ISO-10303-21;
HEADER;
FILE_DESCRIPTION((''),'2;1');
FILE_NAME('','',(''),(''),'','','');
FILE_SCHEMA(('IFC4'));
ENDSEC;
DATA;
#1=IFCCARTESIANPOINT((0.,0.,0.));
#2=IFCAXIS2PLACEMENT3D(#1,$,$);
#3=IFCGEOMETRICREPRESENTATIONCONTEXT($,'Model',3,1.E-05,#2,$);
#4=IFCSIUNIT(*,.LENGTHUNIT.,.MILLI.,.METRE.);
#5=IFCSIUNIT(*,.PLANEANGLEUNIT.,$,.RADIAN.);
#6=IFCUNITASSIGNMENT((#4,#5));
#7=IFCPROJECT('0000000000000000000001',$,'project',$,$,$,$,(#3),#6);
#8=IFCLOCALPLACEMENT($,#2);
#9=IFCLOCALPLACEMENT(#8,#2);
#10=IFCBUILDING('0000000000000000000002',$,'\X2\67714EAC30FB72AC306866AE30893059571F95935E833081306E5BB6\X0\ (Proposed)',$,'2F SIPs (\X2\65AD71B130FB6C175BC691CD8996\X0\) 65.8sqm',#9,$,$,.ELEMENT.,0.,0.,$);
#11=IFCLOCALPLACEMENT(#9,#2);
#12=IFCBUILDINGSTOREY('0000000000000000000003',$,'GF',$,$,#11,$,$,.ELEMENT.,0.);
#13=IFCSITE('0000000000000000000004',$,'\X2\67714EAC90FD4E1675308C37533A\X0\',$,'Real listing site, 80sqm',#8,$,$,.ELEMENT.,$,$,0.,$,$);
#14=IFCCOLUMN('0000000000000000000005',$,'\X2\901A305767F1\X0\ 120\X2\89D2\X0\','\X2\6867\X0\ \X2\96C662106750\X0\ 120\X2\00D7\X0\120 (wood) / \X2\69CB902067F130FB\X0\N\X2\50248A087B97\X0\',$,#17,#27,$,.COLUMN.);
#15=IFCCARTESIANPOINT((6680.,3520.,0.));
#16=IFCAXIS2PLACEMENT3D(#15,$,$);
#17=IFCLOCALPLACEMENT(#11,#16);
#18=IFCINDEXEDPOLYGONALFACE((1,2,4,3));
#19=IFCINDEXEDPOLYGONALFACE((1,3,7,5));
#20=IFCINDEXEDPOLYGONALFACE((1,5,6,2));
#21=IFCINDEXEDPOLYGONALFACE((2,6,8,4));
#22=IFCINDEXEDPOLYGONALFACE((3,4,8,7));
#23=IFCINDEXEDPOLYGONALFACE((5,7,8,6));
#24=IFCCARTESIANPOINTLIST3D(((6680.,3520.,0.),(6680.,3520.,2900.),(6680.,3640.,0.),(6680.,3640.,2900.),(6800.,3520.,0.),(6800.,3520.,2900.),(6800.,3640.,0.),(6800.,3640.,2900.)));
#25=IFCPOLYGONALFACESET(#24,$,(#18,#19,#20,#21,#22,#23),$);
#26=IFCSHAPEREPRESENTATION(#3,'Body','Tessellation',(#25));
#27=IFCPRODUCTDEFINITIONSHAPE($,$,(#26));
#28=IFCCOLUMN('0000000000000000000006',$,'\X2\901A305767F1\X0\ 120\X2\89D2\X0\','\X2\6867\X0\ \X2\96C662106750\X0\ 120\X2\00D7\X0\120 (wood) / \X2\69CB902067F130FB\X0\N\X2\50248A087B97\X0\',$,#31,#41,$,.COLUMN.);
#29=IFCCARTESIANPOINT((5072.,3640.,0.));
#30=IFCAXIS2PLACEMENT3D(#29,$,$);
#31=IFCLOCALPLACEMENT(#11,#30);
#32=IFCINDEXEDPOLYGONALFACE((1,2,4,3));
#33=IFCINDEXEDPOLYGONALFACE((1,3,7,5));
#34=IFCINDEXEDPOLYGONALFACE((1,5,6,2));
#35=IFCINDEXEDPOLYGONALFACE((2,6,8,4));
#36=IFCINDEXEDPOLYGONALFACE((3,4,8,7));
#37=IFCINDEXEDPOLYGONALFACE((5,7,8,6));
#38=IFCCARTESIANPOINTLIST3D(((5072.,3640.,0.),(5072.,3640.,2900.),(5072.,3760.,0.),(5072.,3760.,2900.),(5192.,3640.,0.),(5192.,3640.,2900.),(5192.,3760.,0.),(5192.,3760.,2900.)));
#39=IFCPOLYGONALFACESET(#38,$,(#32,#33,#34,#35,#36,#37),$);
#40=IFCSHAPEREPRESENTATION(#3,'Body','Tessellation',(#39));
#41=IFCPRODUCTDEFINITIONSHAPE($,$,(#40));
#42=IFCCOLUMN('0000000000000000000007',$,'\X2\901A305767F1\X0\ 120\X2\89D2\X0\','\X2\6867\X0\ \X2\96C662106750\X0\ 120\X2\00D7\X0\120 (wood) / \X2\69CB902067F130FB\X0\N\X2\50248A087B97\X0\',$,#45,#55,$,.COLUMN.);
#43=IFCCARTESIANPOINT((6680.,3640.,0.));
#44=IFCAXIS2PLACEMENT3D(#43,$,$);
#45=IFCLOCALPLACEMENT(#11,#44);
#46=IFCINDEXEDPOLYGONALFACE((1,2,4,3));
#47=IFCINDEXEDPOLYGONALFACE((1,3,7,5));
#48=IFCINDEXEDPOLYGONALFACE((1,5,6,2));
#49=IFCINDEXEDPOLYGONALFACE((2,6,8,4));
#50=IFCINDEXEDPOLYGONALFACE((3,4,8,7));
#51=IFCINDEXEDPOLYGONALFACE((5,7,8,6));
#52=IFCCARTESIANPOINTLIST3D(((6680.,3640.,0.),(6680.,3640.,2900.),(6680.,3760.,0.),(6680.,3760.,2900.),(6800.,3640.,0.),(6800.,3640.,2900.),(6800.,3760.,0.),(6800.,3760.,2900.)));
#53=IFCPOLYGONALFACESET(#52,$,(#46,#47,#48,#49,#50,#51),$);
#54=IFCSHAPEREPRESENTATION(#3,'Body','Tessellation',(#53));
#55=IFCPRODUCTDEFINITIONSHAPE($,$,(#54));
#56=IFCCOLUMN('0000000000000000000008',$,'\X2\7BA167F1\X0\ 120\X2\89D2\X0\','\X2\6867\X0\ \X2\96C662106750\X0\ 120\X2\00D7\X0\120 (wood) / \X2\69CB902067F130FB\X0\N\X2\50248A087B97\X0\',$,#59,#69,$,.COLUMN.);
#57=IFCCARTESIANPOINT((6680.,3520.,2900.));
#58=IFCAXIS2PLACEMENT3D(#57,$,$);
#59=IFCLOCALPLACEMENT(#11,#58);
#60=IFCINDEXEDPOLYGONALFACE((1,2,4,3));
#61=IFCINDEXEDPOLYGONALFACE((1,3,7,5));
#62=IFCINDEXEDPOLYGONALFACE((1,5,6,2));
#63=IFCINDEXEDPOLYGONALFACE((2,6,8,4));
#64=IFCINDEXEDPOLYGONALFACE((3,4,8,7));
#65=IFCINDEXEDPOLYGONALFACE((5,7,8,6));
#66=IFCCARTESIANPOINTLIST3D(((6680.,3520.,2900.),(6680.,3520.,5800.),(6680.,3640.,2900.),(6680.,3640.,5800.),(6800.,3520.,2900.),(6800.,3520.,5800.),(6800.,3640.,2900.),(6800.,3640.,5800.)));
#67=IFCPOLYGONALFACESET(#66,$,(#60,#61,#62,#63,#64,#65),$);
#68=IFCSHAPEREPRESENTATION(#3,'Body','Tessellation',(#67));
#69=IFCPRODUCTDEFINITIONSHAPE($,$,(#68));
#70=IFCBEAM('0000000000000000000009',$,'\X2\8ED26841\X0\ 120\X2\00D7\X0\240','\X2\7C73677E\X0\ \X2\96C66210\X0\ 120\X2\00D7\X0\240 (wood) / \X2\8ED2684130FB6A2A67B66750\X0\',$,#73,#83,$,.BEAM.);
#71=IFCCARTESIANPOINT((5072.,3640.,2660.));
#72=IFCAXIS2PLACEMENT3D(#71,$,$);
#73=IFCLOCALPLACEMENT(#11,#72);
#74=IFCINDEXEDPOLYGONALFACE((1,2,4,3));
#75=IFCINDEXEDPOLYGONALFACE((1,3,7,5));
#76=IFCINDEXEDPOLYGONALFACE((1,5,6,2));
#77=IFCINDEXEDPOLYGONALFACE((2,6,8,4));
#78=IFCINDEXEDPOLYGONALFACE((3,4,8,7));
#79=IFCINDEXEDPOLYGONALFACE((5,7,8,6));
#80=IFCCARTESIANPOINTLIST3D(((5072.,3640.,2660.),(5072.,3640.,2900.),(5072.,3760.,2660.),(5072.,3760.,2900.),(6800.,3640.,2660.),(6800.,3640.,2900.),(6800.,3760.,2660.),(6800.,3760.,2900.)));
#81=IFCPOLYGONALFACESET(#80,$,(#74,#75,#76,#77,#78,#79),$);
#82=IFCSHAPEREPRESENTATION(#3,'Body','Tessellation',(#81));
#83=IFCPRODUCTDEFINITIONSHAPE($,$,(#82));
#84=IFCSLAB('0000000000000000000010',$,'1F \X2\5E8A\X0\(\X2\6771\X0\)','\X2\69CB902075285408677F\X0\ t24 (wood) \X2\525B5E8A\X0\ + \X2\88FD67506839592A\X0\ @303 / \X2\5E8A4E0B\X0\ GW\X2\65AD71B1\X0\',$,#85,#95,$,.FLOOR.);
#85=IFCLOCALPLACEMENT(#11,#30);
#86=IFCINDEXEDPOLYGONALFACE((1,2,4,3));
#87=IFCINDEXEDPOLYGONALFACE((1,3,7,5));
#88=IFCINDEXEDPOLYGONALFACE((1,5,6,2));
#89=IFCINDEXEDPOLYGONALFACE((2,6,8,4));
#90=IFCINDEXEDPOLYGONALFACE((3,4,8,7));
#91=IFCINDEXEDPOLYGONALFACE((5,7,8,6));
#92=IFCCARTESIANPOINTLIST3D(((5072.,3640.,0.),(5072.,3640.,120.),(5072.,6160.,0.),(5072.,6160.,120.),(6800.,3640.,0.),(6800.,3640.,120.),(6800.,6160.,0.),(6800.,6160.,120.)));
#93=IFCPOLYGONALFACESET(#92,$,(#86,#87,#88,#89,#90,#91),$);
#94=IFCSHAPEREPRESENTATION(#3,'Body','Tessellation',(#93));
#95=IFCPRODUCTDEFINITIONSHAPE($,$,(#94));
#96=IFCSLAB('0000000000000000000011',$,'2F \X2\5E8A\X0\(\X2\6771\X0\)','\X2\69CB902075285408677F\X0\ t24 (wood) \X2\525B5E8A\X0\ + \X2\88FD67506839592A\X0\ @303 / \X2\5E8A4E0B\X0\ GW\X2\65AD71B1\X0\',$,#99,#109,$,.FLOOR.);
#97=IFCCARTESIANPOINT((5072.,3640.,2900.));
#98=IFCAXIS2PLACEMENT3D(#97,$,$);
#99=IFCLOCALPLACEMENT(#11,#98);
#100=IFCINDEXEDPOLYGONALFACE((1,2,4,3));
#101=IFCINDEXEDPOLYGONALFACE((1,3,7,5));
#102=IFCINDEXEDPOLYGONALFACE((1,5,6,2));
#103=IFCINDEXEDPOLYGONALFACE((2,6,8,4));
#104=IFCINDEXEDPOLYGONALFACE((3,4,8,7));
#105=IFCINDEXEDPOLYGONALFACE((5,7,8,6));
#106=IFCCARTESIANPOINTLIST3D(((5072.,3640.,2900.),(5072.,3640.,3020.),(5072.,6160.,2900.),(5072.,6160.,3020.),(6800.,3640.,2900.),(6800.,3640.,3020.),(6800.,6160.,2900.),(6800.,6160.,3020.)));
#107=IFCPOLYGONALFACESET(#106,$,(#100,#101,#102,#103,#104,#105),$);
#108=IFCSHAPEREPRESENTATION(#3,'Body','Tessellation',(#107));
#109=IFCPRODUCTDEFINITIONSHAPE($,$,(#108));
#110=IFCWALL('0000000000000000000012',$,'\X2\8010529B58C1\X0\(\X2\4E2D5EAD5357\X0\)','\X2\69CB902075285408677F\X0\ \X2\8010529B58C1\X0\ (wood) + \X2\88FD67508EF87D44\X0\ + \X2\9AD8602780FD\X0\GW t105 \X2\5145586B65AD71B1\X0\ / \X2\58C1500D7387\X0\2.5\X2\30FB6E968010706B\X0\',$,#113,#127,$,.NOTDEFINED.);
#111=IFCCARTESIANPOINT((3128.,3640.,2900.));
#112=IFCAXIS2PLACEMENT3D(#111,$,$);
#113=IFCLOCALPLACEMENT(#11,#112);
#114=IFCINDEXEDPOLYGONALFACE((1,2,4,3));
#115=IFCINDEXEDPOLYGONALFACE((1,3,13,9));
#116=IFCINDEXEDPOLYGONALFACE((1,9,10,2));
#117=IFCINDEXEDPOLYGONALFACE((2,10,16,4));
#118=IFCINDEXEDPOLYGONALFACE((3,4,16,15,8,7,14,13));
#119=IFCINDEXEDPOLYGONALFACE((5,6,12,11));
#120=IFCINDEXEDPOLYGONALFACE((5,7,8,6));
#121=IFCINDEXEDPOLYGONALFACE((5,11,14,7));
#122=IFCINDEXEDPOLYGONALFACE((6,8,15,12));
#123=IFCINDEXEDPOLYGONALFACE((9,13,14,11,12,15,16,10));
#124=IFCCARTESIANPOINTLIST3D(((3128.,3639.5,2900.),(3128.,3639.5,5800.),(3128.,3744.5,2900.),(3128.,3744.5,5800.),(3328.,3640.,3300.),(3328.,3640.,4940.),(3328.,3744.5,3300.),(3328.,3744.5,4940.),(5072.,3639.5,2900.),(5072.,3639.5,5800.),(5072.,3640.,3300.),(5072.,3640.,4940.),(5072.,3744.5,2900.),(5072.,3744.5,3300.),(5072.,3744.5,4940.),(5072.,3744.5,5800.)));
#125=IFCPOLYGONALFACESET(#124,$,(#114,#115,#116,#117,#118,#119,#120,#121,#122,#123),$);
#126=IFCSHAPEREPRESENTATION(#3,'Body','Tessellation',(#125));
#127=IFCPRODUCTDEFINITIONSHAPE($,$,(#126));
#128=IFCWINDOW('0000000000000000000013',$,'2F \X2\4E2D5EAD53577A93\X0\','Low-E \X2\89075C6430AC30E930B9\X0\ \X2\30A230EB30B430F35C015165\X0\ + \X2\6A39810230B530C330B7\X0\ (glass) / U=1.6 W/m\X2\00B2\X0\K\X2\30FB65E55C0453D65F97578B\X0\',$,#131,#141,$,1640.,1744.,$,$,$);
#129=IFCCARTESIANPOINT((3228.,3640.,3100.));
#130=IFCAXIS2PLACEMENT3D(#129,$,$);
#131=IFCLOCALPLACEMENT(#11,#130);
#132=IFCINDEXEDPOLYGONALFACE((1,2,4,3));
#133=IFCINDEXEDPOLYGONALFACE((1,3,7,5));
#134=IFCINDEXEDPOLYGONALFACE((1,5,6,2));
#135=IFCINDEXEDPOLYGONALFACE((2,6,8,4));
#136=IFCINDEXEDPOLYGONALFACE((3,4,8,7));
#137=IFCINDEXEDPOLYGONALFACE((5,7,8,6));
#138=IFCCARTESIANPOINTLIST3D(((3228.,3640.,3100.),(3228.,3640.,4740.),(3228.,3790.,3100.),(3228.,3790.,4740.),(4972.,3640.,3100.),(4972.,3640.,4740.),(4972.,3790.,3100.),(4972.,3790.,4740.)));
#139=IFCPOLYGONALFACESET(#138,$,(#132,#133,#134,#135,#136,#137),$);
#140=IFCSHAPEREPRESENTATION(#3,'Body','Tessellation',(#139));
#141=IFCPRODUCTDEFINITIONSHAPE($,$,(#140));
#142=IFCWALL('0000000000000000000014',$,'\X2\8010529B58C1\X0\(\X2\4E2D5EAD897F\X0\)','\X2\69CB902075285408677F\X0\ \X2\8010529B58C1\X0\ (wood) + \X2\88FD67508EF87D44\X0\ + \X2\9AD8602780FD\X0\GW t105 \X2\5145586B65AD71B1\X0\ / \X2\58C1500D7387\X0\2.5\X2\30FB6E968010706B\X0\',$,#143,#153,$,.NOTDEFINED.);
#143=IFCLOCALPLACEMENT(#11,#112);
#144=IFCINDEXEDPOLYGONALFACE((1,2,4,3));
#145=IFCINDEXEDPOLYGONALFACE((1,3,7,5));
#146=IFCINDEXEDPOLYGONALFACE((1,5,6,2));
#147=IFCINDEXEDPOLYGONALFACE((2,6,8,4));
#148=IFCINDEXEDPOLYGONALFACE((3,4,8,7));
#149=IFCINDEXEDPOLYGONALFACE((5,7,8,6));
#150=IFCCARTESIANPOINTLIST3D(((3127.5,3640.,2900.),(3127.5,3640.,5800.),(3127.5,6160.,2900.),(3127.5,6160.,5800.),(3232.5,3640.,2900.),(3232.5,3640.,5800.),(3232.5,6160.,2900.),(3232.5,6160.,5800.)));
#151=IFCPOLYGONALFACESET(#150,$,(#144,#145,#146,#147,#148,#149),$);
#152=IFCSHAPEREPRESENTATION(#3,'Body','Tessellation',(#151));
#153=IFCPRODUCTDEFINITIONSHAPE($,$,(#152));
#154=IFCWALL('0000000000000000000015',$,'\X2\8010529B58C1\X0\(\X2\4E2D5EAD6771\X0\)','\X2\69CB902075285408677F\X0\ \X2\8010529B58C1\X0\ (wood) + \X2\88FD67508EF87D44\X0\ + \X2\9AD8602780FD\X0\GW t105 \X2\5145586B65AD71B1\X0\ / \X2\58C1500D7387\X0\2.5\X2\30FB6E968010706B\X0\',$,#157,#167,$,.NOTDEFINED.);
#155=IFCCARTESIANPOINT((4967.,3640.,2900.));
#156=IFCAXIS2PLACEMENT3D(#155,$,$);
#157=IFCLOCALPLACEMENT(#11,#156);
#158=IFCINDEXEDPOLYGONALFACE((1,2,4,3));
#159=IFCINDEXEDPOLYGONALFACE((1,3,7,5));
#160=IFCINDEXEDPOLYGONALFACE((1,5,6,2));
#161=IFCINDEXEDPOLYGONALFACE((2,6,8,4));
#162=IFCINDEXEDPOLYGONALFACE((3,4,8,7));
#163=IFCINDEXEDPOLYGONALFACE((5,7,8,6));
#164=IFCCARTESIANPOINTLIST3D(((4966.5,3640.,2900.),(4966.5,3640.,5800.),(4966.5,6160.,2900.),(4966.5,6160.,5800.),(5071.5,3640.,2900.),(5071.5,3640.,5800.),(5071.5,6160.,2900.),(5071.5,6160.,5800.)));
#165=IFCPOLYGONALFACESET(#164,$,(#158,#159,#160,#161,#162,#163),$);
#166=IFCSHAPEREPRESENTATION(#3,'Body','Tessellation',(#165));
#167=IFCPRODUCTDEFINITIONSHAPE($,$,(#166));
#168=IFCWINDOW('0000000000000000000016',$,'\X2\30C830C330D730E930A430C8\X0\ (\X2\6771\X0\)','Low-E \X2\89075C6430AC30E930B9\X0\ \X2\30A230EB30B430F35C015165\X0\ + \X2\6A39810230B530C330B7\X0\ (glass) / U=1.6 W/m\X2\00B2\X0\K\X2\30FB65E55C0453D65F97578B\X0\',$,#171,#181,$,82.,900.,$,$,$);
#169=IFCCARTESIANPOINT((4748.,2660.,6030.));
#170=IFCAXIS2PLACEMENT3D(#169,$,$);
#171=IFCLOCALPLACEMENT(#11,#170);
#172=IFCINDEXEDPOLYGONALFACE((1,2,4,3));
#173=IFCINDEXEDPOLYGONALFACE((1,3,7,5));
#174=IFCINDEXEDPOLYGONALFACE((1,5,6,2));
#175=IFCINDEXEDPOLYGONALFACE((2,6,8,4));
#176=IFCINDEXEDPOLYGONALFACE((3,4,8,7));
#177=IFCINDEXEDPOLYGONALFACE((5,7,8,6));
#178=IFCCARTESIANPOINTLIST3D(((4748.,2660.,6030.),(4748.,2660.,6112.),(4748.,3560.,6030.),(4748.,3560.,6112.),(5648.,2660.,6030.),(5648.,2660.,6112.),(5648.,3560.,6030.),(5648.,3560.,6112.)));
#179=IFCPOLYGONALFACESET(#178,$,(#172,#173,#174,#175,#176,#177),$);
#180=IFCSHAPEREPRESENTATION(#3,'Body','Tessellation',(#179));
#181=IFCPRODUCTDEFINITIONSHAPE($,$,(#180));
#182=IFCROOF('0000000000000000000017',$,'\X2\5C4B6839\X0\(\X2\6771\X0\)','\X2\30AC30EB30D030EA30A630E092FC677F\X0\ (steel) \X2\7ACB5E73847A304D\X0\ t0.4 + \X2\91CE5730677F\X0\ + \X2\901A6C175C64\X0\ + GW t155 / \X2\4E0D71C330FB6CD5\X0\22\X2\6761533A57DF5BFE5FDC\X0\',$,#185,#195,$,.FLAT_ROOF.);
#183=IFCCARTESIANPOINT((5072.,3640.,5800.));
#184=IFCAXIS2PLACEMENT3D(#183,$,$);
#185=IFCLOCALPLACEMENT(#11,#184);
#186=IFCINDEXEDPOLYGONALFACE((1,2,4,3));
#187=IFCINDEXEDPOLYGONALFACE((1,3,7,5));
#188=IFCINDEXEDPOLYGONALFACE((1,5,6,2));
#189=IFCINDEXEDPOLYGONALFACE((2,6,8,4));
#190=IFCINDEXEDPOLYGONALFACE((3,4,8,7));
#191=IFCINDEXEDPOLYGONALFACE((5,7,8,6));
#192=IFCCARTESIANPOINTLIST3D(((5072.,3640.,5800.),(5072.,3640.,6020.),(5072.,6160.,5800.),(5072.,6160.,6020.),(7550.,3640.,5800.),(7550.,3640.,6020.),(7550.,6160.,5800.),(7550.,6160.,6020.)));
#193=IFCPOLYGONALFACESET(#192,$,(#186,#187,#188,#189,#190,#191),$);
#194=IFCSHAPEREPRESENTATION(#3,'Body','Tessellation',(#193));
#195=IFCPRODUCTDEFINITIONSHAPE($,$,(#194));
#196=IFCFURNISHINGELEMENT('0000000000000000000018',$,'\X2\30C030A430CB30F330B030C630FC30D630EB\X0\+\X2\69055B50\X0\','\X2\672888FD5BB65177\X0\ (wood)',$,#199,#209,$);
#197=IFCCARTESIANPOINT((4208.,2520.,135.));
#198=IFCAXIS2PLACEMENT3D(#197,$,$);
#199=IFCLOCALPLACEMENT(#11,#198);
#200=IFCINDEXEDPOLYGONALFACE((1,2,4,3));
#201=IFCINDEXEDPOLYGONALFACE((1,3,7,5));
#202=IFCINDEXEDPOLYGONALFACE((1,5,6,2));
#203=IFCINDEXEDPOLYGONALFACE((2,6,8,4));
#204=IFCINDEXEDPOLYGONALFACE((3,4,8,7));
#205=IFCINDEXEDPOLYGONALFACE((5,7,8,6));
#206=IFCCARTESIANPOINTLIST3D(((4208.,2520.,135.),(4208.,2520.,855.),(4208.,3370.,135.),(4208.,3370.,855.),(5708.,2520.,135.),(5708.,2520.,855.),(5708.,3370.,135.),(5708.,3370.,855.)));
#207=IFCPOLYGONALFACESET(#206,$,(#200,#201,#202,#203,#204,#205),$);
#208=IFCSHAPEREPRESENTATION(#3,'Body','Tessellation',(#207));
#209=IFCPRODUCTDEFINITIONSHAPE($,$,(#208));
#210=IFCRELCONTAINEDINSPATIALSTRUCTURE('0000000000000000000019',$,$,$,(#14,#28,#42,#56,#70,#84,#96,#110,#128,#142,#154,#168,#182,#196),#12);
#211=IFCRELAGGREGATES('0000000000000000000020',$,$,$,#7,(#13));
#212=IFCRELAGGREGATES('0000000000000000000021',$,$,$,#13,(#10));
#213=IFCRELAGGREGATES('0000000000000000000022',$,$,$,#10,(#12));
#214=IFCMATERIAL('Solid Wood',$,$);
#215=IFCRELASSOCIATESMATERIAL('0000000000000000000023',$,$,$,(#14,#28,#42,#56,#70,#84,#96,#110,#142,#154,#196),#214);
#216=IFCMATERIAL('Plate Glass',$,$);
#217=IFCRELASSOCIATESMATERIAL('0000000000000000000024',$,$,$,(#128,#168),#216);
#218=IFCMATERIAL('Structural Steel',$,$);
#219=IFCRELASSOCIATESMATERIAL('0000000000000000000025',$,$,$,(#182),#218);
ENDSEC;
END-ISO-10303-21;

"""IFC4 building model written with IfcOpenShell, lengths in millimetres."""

from ifc_helpers import new_model, si_unit, frame, frame_2d, origin, place, context, project, spatial, rectangle, extrude, material, element, fill, save


model = new_model("IFC4")

# Units and contexts
model_context = context("Model", 3, precision=1e-05, world=origin())
ifc_project = project(units=[si_unit("LENGTHUNIT", "METRE", prefix="MILLI"), si_unit("PLANEANGLEUNIT", "RADIAN")], contexts=[model_context])

# Site, building, storey
site_placement = place(None, origin())
site = spatial("IfcSite", under=ifc_project, at=site_placement, Name="東京都世田谷区", ObjectType="Real listing site, 80sqm", CompositionType="ELEMENT", RefElevation=0.0)
building_placement = place(site_placement, origin())
building = spatial("IfcBuilding", under=site, at=building_placement, Name="東京・犬と暮らす土間広めの家 (Proposed)", ObjectType="2F SIPs (断熱・気密重視) 65.8sqm", CompositionType="ELEMENT", ElevationOfRefHeight=0.0, ElevationOfTerrain=0.0)
storey_placement = place(building_placement, origin())
storey = spatial("IfcBuildingStorey", under=building, at=storey_placement, Name="GF", CompositionType="ELEMENT", Elevation=0.0)

# Columns
ifc_material_1 = material(Name="Solid Wood")
column_1_placement = place(storey_placement, frame((6680.0, 3520.0, 0.0)))
element("IfcColumn", 1, at=column_1_placement, inside=storey, material=ifc_material_1, Name="通し柱 120角", Description="桧 集成材 120×120 (wood) / 構造柱・N値計算", PredefinedType="COLUMN", context=model_context, shape_type="SweptSolid", body=[
    extrude(rectangle(XDim=120.0, YDim=120.0, at=frame_2d((60.0, 60.0))), frame((6680.0, 3520.0, 0.0)), (0.0, 0.0, 1.0), 2900.0),
])
column_2_placement = place(storey_placement, frame((5072.0, 3640.0, 0.0)))
element("IfcColumn", 2, at=column_2_placement, inside=storey, material=ifc_material_1, Name="通し柱 120角", Description="桧 集成材 120×120 (wood) / 構造柱・N値計算", PredefinedType="COLUMN", context=model_context, shape_type="SweptSolid", body=[
    extrude(rectangle(XDim=120.0, YDim=120.0, at=frame_2d((60.0, 60.0))), frame((5072.0, 3640.0, 0.0)), (0.0, 0.0, 1.0), 2900.0),
])
column_3_placement = place(storey_placement, frame((6680.0, 3640.0, 0.0)))
element("IfcColumn", 3, at=column_3_placement, inside=storey, material=ifc_material_1, Name="通し柱 120角", Description="桧 集成材 120×120 (wood) / 構造柱・N値計算", PredefinedType="COLUMN", context=model_context, shape_type="SweptSolid", body=[
    extrude(rectangle(XDim=120.0, YDim=120.0, at=frame_2d((60.0, 60.0))), frame((6680.0, 3640.0, 0.0)), (0.0, 0.0, 1.0), 2900.0),
])
column_4_placement = place(storey_placement, frame((6680.0, 3520.0, 2900.0)))
element("IfcColumn", 4, at=column_4_placement, inside=storey, material=ifc_material_1, Name="管柱 120角", Description="桧 集成材 120×120 (wood) / 構造柱・N値計算", PredefinedType="COLUMN", context=model_context, shape_type="SweptSolid", body=[
    extrude(rectangle(XDim=120.0, YDim=120.0, at=frame_2d((60.0, 60.0))), frame((6680.0, 3520.0, 2900.0)), (0.0, 0.0, 1.0), 2900.0),
])

# Beam
beam_1_placement = place(storey_placement, frame((5072.0, 3640.0, 2660.0)))
element("IfcBeam", 5, at=beam_1_placement, inside=storey, material=ifc_material_1, Name="軒桁 120×240", Description="米松 集成 120×240 (wood) / 軒桁・横架材", PredefinedType="BEAM", context=model_context, shape_type="SweptSolid", body=[
    extrude(rectangle(XDim=1728.0, YDim=120.0, at=frame_2d((864.0, 60.0))), frame((5072.0, 3640.0, 2660.0)), (0.0, 0.0, 1.0), 240.0),
])

# Slabs
slab_1_placement = place(storey_placement, frame((5072.0, 3640.0, 0.0)))
element("IfcSlab", 6, at=slab_1_placement, inside=storey, material=ifc_material_1, Name="1F 床(東)", Description="構造用合板 t24 (wood) 剛床 + 製材根太 @303 / 床下 GW断熱", PredefinedType="FLOOR", context=model_context, shape_type="SweptSolid", body=[
    extrude(rectangle(XDim=1728.0, YDim=2520.0, at=frame_2d((864.0, 1260.0))), frame((5072.0, 3640.0, 0.0)), (0.0, 0.0, 1.0), 120.0),
])
slab_2_placement = place(storey_placement, frame((5072.0, 3640.0, 2900.0)))
element("IfcSlab", 7, at=slab_2_placement, inside=storey, material=ifc_material_1, Name="2F 床(東)", Description="構造用合板 t24 (wood) 剛床 + 製材根太 @303 / 床下 GW断熱", PredefinedType="FLOOR", context=model_context, shape_type="SweptSolid", body=[
    extrude(rectangle(XDim=1728.0, YDim=2520.0, at=frame_2d((864.0, 1260.0))), frame((5072.0, 3640.0, 2900.0)), (0.0, 0.0, 1.0), 120.0),
])

# Wall, opening, window
wall_1_placement = place(storey_placement, frame((3128.0, 3640.0, 2900.0)))
wall_1 = element("IfcWall", 8, at=wall_1_placement, inside=storey, material=ifc_material_1, Name="耐力壁(中庭南)", Description="構造用合板 耐力壁 (wood) + 製材軸組 + 高性能GW t105 充填断熱 / 壁倍率2.5・準耐火", PredefinedType="NOTDEFINED", context=model_context, shape_type="SweptSolid", body=[
    extrude(rectangle(XDim=1944.0, YDim=105.0, at=frame_2d((972.0, 52.0))), frame((3128.0, 3640.0, 2900.0)), (0.0, 0.0, 1.0), 2900.0),
])
opening_placement = place(storey_placement, frame((3228.0, 3640.0, 3100.0)))
opening = element("IfcOpeningElement", 9, at=opening_placement, cuts=wall_1, PredefinedType="NOTDEFINED", context=model_context, shape_type="SweptSolid", body=[
    extrude(rectangle(XDim=1744.0, YDim=150.0, at=frame_2d((872.0, 75.0))), frame((3228.0, 3640.0, 3100.0)), (0.0, 0.0, 1.0), 1640.0),
])
ifc_material_2 = material(Name="Plate Glass")
window_1_placement = place(storey_placement, frame((3228.0, 3640.0, 3100.0)))
window_1 = element("IfcWindow", 10, at=window_1_placement, inside=storey, material=ifc_material_2, Name="2F 中庭南窓", Description="Low-E 複層ガラス アルゴン封入 + 樹脂サッシ (glass) / U=1.6 W/m²K・日射取得型", OverallHeight=1640.0, OverallWidth=1744.0, context=model_context, shape_type="SweptSolid", body=[
    extrude(rectangle(XDim=1744.0, YDim=150.0, at=frame_2d((872.0, 75.0))), frame((3228.0, 3640.0, 3100.0)), (0.0, 0.0, 1.0), 1640.0),
])
fill(opening, window_1)

# Walls
wall_2_placement = place(storey_placement, frame((3128.0, 3640.0, 2900.0)))
element("IfcWall", 11, at=wall_2_placement, inside=storey, material=ifc_material_1, Name="耐力壁(中庭西)", Description="構造用合板 耐力壁 (wood) + 製材軸組 + 高性能GW t105 充填断熱 / 壁倍率2.5・準耐火", PredefinedType="NOTDEFINED", context=model_context, shape_type="SweptSolid", body=[
    extrude(rectangle(XDim=105.0, YDim=2520.0, at=frame_2d((52.0, 1260.0))), frame((3128.0, 3640.0, 2900.0)), (0.0, 0.0, 1.0), 2900.0),
])
wall_3_placement = place(storey_placement, frame((4967.0, 3640.0, 2900.0)))
element("IfcWall", 12, at=wall_3_placement, inside=storey, material=ifc_material_1, Name="耐力壁(中庭東)", Description="構造用合板 耐力壁 (wood) + 製材軸組 + 高性能GW t105 充填断熱 / 壁倍率2.5・準耐火", PredefinedType="NOTDEFINED", context=model_context, shape_type="SweptSolid", body=[
    extrude(rectangle(XDim=105.0, YDim=2520.0, at=frame_2d((52.0, 1260.0))), frame((4967.0, 3640.0, 2900.0)), (0.0, 0.0, 1.0), 2900.0),
])

# Window
window_2_placement = place(storey_placement, frame((4748.0, 2660.0, 6030.0)))
element("IfcWindow", 13, at=window_2_placement, inside=storey, material=ifc_material_2, Name="トップライト (東)", Description="Low-E 複層ガラス アルゴン封入 + 樹脂サッシ (glass) / U=1.6 W/m²K・日射取得型", OverallHeight=82.0, OverallWidth=900.0, context=model_context, shape_type="SweptSolid", body=[
    extrude(rectangle(XDim=900.0, YDim=900.0, at=frame_2d((450.0, 450.0))), frame((4748.0, 2660.0, 6030.0)), (0.0, 0.0, 1.0), 82.0),
])

# Roof
ifc_material_3 = material(Name="Structural Steel")
for number, where, name in (
    (14, (5072.0, 3640.0, 5800.0), "屋根(東)"),
):
    element("IfcRoof", number, at=place(storey_placement, frame(where)), inside=storey, material=ifc_material_3, Name=name, Description="ガルバリウム鋼板 (steel) 立平葺き t0.4 + 野地板 + 通気層 + GW t155 / 不燃・法22条区域対応", PredefinedType="FLAT_ROOF", context=model_context, shape_type="SweptSolid", body=[
        extrude(rectangle(XDim=2478.0, YDim=2520.0, at=frame_2d((1239.0, 1260.0))), frame((5072.0, 3640.0, 5800.0)), (0.0, 0.0, 1.0), 220.0),
    ])

# Furnishing element
furnishing_1_placement = place(storey_placement, frame((4208.0, 2520.0, 135.0)))
element("IfcFurnishingElement", 15, at=furnishing_1_placement, inside=storey, material=ifc_material_1, Name="ダイニングテーブル+椅子", Description="木製家具 (wood)", context=model_context, shape_type="SweptSolid", body=[
    extrude(rectangle(XDim=1500.0, YDim=850.0, at=frame_2d((750.0, 425.0))), frame((4208.0, 2520.0, 135.0)), (0.0, 0.0, 1.0), 720.0),
])

save(model, "model.ifc")
